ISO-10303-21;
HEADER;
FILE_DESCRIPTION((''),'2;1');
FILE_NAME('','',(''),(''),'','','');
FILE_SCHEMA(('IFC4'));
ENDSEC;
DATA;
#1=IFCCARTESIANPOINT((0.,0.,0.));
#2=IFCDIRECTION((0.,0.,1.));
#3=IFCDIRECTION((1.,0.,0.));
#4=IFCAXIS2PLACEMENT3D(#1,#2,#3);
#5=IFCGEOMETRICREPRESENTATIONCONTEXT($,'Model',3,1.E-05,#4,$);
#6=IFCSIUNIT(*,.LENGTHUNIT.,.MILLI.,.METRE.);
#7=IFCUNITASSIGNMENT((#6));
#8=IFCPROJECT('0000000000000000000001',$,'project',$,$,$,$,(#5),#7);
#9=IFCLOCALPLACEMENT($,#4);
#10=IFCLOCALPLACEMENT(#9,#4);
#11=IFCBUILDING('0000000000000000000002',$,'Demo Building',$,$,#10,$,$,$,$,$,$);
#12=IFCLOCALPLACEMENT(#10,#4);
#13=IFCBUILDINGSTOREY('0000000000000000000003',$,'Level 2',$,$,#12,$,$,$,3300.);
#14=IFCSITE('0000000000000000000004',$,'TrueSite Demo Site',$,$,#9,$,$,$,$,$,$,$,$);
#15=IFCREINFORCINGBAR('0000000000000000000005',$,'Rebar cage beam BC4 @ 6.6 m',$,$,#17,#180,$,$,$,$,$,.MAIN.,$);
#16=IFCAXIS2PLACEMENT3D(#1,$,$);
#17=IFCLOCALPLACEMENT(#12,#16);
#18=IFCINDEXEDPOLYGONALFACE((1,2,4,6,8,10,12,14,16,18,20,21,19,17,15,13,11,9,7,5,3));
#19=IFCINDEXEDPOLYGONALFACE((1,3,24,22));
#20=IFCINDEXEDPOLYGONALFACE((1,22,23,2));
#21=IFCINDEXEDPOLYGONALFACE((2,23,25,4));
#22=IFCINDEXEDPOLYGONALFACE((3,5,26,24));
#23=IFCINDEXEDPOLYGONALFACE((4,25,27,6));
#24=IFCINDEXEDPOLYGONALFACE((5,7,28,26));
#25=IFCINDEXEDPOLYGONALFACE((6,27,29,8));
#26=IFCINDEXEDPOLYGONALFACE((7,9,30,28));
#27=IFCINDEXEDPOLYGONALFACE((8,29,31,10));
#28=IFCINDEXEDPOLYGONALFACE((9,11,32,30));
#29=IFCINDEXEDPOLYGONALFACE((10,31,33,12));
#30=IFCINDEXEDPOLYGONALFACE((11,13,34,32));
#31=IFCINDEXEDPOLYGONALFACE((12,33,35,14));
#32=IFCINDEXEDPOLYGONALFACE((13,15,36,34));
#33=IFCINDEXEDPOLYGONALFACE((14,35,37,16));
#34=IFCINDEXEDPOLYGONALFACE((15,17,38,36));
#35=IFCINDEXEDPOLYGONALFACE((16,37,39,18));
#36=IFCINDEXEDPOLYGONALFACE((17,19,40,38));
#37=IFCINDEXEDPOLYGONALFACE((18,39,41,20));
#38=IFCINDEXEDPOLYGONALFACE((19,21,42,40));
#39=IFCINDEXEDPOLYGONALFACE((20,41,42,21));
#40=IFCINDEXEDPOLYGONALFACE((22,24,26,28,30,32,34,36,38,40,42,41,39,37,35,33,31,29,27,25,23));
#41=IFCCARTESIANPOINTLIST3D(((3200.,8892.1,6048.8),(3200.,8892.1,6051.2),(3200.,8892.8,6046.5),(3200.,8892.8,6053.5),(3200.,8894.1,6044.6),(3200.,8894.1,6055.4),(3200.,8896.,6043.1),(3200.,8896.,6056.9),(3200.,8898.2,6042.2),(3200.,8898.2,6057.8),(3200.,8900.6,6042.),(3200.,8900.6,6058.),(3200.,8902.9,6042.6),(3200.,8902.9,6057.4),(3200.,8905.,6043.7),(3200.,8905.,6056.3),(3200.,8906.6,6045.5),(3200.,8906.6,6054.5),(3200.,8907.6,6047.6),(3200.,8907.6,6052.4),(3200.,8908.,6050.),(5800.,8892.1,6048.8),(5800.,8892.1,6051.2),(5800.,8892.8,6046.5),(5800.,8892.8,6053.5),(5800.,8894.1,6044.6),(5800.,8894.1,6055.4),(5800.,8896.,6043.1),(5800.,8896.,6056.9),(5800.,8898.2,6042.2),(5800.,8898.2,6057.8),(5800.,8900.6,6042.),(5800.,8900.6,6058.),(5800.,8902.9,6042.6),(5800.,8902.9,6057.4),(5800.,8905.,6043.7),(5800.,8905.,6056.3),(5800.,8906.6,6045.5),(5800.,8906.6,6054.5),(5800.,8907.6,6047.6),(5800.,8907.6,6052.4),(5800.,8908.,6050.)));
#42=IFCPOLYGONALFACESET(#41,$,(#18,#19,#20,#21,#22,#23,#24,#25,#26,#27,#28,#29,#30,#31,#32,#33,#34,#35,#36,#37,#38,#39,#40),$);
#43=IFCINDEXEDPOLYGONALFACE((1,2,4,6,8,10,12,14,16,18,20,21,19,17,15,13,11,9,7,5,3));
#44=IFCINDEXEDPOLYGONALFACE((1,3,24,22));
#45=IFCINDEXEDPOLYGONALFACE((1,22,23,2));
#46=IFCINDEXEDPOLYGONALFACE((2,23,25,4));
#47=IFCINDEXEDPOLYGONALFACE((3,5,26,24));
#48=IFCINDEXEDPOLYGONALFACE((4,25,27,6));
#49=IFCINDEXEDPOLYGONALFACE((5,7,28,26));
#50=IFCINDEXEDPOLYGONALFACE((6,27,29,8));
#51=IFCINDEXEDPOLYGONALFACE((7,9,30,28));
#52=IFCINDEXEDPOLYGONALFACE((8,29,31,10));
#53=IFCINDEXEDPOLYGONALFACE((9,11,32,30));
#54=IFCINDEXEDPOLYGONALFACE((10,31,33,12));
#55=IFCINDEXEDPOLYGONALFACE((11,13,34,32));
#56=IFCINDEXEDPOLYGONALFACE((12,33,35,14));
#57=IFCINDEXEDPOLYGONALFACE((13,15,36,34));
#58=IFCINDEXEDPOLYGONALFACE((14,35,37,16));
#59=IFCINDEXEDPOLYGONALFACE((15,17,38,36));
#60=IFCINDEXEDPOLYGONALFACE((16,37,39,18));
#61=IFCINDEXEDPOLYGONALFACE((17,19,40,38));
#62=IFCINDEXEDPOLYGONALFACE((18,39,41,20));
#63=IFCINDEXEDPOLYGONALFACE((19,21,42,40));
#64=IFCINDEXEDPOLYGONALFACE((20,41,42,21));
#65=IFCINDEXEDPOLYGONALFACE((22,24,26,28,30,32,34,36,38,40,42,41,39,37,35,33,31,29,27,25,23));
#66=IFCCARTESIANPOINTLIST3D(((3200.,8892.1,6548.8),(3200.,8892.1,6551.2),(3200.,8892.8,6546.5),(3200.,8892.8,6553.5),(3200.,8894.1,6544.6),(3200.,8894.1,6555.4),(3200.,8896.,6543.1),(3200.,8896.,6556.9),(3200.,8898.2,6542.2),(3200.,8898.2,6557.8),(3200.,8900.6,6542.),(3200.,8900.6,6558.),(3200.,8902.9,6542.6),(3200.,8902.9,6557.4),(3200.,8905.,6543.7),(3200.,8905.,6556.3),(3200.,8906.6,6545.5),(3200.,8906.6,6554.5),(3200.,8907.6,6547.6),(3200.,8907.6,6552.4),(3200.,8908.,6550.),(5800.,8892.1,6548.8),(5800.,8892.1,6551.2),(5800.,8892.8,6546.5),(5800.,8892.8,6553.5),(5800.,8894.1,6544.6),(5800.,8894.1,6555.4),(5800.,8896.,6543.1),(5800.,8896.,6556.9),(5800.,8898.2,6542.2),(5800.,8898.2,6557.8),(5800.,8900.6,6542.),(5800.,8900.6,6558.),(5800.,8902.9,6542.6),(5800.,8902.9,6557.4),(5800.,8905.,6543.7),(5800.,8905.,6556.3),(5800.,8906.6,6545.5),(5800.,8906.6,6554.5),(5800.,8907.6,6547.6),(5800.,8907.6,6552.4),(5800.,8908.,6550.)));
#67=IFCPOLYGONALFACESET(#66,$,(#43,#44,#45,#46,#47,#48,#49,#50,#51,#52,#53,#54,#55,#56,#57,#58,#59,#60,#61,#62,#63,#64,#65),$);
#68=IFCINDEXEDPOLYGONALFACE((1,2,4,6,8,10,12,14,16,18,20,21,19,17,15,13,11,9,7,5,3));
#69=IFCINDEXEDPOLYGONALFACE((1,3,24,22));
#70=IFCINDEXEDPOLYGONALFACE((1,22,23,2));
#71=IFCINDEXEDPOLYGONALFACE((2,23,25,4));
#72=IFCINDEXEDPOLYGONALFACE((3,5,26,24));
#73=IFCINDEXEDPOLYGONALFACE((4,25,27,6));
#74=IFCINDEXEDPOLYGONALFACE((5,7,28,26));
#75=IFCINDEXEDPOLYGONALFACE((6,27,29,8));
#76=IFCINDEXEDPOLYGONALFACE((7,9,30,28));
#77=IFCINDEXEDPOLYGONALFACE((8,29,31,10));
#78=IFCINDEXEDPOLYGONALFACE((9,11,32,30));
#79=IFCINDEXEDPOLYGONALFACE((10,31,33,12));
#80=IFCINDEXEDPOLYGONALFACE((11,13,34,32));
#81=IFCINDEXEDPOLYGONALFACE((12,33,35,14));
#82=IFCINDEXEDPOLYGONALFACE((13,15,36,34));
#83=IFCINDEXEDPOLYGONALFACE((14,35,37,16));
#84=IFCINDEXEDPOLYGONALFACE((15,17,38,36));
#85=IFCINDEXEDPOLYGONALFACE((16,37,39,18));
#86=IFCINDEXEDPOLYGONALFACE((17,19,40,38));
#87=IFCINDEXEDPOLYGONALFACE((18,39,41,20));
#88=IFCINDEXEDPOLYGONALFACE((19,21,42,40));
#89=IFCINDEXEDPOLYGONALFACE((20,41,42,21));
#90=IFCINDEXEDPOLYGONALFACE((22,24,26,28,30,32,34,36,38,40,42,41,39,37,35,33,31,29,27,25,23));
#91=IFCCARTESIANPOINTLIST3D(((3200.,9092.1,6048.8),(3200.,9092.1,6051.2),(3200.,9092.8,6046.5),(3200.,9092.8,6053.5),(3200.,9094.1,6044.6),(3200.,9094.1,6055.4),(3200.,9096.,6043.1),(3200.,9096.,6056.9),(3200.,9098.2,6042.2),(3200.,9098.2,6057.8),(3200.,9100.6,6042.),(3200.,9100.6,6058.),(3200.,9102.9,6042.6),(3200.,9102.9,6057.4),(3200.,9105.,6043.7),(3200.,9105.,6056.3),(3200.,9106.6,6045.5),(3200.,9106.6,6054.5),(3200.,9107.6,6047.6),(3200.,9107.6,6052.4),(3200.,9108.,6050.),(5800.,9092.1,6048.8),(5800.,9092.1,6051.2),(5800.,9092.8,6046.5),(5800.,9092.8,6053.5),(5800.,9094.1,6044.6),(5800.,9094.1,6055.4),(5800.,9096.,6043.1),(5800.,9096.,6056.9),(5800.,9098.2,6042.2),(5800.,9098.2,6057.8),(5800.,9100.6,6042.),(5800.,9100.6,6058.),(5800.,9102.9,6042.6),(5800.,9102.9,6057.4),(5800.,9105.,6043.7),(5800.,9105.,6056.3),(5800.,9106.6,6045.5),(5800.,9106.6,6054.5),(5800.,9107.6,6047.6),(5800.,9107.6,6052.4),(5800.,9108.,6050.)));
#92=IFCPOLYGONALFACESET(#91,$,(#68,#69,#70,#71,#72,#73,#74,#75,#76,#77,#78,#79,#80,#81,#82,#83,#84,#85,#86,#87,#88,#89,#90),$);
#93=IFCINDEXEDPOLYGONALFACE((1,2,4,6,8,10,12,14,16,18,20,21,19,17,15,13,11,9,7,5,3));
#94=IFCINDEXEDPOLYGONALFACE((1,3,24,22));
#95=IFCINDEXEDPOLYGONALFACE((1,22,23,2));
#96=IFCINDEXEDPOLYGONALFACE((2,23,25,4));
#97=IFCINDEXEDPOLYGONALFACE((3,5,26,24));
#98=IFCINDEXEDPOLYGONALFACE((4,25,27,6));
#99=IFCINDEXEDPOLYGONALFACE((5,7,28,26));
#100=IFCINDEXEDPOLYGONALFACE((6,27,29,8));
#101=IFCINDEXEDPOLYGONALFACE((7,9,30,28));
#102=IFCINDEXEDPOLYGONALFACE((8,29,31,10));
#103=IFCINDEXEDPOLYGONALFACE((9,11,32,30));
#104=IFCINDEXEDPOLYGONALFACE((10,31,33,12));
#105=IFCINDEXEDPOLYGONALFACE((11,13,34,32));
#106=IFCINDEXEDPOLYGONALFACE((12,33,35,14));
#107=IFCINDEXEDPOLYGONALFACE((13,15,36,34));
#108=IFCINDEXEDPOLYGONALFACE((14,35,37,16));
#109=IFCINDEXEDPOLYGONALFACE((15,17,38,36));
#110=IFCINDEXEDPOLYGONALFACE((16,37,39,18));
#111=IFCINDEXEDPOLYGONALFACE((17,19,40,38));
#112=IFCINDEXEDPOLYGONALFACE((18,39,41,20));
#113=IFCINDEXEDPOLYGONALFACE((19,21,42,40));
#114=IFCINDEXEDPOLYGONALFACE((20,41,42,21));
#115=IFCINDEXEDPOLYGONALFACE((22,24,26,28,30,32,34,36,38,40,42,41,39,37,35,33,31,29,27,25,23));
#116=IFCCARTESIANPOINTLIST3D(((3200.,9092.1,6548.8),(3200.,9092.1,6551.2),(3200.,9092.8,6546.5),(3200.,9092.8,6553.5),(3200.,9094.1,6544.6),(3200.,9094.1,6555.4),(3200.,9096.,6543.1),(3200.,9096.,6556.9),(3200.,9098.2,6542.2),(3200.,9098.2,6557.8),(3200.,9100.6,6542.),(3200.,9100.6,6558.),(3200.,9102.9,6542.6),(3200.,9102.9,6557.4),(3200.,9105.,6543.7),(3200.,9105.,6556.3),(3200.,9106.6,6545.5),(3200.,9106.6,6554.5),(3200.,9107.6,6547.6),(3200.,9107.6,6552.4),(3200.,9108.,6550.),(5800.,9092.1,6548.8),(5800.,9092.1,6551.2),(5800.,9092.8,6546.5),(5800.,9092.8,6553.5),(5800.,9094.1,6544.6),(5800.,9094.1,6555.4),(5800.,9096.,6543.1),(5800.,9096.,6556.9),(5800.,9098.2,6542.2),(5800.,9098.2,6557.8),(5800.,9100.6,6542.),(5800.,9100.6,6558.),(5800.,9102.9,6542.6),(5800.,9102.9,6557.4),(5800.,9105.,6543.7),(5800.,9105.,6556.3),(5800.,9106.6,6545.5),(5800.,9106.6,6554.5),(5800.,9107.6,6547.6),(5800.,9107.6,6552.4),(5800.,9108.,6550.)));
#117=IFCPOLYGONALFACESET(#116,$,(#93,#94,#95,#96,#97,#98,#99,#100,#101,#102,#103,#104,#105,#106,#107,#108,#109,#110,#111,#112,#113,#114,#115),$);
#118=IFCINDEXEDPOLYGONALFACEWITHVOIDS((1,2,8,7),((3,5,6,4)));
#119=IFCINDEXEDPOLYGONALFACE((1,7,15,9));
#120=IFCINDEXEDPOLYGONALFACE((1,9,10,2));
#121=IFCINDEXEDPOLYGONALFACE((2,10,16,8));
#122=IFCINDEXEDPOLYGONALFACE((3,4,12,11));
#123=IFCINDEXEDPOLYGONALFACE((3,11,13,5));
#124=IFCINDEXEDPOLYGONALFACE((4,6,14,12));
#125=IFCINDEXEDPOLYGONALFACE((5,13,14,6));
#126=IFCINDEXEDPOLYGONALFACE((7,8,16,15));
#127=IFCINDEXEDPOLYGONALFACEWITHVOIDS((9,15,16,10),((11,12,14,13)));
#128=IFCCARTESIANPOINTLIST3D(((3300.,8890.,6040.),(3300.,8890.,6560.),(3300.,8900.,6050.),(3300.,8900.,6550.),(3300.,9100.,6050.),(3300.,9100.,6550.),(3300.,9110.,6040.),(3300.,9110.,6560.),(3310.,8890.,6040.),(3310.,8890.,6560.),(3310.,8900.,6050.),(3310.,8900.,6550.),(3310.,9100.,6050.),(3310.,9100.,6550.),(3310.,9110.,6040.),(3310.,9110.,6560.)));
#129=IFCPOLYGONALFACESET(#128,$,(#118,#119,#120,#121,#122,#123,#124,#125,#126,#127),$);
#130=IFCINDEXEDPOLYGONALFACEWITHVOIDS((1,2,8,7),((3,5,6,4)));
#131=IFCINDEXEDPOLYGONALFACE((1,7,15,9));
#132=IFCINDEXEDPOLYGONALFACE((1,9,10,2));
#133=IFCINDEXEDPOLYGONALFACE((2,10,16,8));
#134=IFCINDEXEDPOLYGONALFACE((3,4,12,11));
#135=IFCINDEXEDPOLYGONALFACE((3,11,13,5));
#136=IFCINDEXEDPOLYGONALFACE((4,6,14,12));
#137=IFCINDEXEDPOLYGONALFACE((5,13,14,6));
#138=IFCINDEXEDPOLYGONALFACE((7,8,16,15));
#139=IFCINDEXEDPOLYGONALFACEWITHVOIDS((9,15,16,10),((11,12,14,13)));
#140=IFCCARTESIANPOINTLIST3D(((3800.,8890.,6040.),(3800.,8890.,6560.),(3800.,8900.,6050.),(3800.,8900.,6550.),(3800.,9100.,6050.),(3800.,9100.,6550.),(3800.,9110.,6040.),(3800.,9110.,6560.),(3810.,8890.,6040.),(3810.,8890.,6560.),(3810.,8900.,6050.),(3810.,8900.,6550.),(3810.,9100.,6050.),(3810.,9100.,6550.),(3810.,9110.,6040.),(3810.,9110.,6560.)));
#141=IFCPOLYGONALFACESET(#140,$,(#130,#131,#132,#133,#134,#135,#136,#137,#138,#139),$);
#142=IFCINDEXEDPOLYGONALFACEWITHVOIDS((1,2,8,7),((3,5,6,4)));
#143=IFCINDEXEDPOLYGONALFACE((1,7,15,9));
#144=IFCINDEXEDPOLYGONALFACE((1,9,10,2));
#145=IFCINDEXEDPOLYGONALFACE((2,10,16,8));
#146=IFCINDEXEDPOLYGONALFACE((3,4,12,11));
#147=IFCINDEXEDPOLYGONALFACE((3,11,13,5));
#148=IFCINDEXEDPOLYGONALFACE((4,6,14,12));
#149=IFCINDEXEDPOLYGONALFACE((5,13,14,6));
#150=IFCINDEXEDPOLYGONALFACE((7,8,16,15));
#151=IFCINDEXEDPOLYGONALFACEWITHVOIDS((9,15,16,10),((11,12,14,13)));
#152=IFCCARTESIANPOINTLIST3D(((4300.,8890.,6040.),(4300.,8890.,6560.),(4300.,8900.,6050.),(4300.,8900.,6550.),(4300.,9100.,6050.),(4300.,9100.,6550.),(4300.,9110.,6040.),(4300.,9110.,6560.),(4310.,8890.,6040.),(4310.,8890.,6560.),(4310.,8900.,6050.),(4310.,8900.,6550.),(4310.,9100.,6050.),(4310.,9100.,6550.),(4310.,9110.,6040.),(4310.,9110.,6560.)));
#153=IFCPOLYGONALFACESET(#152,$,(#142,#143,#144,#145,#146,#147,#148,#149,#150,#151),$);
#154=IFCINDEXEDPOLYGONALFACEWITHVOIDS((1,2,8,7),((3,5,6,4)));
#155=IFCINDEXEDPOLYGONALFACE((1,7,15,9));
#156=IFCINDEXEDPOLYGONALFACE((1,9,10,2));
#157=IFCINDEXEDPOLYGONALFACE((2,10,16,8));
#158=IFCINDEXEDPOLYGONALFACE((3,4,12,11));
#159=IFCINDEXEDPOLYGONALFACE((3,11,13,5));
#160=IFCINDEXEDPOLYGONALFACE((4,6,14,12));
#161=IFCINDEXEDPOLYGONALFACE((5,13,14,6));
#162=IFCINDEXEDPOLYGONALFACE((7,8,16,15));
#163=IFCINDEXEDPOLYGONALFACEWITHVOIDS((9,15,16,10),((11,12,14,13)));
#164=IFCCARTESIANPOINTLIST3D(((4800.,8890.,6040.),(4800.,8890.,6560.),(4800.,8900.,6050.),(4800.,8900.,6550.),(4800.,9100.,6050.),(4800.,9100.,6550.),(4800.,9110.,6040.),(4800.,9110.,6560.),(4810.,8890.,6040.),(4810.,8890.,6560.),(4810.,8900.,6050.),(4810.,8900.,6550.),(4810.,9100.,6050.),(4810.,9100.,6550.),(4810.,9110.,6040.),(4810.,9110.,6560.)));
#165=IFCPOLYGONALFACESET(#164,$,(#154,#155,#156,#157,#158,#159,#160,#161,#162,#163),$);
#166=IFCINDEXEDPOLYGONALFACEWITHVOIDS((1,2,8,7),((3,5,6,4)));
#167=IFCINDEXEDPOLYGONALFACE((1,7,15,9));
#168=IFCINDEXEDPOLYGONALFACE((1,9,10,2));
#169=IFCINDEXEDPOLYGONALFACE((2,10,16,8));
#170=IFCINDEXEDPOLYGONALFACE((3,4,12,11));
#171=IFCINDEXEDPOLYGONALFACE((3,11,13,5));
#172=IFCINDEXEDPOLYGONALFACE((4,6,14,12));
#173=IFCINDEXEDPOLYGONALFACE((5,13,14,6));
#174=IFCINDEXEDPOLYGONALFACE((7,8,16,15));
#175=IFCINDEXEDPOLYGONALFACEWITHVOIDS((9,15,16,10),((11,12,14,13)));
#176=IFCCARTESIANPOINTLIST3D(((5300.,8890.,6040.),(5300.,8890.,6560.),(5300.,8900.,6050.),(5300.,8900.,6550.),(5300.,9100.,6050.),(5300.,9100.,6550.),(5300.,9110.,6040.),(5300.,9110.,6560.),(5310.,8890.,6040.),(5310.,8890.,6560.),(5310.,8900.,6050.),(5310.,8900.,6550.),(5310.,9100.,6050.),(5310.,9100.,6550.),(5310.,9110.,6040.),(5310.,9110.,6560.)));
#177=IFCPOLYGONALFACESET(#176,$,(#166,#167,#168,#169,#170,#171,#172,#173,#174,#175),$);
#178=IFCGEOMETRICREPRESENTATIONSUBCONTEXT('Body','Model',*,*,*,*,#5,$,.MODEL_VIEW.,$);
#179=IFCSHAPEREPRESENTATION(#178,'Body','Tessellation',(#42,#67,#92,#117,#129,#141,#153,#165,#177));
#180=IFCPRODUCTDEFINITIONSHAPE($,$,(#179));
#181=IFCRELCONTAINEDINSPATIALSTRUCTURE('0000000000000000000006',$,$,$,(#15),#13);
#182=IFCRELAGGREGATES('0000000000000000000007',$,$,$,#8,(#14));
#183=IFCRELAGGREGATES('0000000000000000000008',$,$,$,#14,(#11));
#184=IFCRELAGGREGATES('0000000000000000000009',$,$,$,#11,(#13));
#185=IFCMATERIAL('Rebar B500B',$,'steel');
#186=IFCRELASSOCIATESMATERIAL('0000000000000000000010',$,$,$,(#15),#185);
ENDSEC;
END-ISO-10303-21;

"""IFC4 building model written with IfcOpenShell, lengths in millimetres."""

from ifc_helpers import new_model, si_unit, frame, origin_with_axes, place, context, subcontext, project, spatial, hollow_rectangle, circle, extrude, material, element, save


model = new_model("IFC4")

# Units and contexts
model_context = context("Model", 3, precision=1e-05, world=origin_with_axes())
body_context = subcontext(model_context, "Body", "Model", "MODEL_VIEW")
ifc_project = project(units=[si_unit("LENGTHUNIT", "METRE", prefix="MILLI")], contexts=[model_context])

# Site, building, storey
site_placement = place(None, origin_with_axes())
site = spatial("IfcSite", under=ifc_project, at=site_placement, Name="TrueSite Demo Site")
building_placement = place(site_placement, origin_with_axes())
building = spatial("IfcBuilding", under=site, at=building_placement, Name="Demo Building")
storey_placement = place(building_placement, origin_with_axes())
storey = spatial("IfcBuildingStorey", under=building, at=storey_placement, Name="Level 2", Elevation=3300.0)

# Reinforcing bar
ifc_material_1 = material(Name="Rebar B500B", Category="steel")
for number, where, z_axis, x_axis, name in (
    (1, (3200.0, 9000.0, 6300.0), (1.0, 0.0, 0.0), (0.0, 1.0, 0.0), "Rebar cage beam BC4 @ 6.6 m"),
):
    element("IfcReinforcingBar", number, at=place(storey_placement, frame(where, z_axis=z_axis, x_axis=x_axis)), inside=storey, material=ifc_material_1, Name=name, PredefinedType="MAIN", context=body_context, shape_type="SweptSolid", body=[
        extrude(circle(Radius=8.0), frame((-100.0, -250.0, 0.0)), (0.0, 0.0, 1.0), 2600.0),
        extrude(circle(Radius=8.0), frame((-100.0, 250.0, 0.0)), (0.0, 0.0, 1.0), 2600.0),
        extrude(circle(Radius=8.0), frame((100.0, -250.0, 0.0)), (0.0, 0.0, 1.0), 2600.0),
        extrude(circle(Radius=8.0), frame((100.0, 250.0, 0.0)), (0.0, 0.0, 1.0), 2600.0),
        extrude(hollow_rectangle(XDim=220.0, YDim=520.0, WallThickness=10.0), frame((0.0, 0.0, 100.0)), (0.0, 0.0, 1.0), 10.0),
        extrude(hollow_rectangle(XDim=220.0, YDim=520.0, WallThickness=10.0), frame((0.0, 0.0, 600.0)), (0.0, 0.0, 1.0), 10.0),
        extrude(hollow_rectangle(XDim=220.0, YDim=520.0, WallThickness=10.0), frame((0.0, 0.0, 1100.0)), (0.0, 0.0, 1.0), 10.0),
        extrude(hollow_rectangle(XDim=220.0, YDim=520.0, WallThickness=10.0), frame((0.0, 0.0, 1600.0)), (0.0, 0.0, 1.0), 10.0),
        extrude(hollow_rectangle(XDim=220.0, YDim=520.0, WallThickness=10.0), frame((0.0, 0.0, 2100.0)), (0.0, 0.0, 1.0), 10.0),
    ])

save(model, "model.ifc")
